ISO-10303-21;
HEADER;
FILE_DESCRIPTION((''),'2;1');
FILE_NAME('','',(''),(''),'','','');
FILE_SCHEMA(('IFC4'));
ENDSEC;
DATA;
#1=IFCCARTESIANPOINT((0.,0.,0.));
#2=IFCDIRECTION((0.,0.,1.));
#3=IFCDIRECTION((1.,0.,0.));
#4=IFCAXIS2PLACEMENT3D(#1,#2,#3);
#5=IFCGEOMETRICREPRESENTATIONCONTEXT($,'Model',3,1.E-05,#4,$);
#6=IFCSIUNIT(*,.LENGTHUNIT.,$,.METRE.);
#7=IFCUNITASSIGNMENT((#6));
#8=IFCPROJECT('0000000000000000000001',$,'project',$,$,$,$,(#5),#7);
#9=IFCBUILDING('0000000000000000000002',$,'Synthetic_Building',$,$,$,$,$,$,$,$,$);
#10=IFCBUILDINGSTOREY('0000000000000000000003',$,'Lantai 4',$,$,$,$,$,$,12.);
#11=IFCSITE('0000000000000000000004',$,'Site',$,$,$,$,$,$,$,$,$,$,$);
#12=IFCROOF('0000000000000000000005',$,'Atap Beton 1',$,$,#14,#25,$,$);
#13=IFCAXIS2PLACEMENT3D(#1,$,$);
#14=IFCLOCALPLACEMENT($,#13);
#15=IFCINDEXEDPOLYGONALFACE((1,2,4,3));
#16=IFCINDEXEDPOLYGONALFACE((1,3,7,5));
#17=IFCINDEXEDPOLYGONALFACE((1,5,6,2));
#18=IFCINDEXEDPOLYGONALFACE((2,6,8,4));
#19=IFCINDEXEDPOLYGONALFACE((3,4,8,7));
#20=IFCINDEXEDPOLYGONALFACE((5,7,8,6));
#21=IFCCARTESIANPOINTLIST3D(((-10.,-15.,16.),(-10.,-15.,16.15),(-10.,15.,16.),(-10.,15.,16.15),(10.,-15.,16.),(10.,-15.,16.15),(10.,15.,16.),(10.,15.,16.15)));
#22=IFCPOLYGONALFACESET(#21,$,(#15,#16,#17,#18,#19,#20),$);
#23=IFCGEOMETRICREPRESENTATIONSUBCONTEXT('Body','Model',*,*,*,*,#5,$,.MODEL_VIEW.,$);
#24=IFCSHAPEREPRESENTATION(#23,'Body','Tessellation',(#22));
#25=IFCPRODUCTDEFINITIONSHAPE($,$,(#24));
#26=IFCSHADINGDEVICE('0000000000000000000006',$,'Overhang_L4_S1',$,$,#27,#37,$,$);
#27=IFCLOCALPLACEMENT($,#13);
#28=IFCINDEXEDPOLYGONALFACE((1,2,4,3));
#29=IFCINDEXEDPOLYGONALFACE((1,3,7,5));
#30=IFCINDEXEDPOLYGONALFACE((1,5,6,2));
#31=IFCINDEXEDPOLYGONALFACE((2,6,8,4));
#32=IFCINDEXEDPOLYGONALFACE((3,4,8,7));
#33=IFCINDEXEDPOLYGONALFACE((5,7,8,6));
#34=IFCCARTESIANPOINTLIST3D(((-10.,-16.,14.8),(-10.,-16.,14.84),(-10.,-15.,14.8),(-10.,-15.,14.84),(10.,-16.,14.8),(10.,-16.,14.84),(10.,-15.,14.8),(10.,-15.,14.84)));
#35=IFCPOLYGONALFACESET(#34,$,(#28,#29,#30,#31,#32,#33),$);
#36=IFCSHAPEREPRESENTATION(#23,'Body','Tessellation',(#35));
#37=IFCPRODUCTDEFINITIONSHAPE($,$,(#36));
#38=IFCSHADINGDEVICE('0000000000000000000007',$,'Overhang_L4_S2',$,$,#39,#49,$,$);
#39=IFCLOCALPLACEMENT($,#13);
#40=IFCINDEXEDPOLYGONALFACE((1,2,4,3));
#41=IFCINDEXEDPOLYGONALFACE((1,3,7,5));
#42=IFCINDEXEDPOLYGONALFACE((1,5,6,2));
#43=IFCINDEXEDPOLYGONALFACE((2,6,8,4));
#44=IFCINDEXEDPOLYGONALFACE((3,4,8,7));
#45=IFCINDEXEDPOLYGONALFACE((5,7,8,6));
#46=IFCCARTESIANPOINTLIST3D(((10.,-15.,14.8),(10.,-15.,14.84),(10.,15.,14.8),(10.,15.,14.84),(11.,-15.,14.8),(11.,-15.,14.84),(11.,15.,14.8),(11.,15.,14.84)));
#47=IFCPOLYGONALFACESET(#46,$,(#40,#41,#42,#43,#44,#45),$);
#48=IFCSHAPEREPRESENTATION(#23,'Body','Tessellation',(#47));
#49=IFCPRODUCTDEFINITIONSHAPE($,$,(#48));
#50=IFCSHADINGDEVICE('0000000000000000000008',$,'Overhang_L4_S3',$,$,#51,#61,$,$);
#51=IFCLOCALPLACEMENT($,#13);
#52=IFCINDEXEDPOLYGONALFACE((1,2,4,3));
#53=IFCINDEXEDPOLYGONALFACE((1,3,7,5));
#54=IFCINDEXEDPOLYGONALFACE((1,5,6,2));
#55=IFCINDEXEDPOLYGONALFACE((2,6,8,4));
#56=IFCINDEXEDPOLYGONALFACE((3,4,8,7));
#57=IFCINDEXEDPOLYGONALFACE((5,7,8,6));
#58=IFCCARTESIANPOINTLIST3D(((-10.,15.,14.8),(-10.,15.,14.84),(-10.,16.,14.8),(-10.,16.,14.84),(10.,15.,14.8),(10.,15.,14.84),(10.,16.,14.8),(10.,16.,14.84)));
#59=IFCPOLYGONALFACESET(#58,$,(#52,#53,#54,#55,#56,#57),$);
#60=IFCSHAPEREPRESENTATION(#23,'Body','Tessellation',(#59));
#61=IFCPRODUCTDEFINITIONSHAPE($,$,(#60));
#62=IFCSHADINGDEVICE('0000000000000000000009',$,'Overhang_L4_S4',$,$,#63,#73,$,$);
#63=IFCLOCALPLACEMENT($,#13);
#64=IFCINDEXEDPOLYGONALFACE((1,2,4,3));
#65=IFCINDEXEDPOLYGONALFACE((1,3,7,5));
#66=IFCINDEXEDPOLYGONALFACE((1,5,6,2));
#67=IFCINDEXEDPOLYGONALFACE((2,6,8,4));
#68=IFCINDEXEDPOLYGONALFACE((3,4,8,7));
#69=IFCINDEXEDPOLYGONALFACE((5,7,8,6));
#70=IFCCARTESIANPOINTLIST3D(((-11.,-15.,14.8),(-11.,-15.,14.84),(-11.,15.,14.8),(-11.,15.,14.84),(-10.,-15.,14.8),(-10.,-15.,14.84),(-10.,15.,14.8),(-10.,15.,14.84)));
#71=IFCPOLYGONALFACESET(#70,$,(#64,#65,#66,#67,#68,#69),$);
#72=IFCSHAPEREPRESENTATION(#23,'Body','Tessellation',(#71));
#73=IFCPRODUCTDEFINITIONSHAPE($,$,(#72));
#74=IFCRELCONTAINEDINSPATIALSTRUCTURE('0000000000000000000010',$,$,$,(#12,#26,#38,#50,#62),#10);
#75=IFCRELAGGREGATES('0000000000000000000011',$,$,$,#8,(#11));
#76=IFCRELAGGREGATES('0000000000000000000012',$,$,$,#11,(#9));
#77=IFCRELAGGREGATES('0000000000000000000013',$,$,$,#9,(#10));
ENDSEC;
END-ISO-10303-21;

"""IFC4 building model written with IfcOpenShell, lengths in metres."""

from ifc_helpers import new_model, si_unit, frame, origin_with_axes, place, context, subcontext, project, spatial, polyline, outline, extrude, element, save


model = new_model("IFC4")

# Units and contexts
model_context = context("Model", 3, precision=1e-05, world=origin_with_axes())
body_context = subcontext(model_context, "Body", "Model", "MODEL_VIEW")
ifc_project = project(units=[si_unit("LENGTHUNIT", "METRE")], contexts=[model_context])

# Site, building, storey
site = spatial("IfcSite", under=ifc_project, Name="Site")
building = spatial("IfcBuilding", under=site, Name="Synthetic_Building")
storey = spatial("IfcBuildingStorey", under=building, Name="Lantai 4", Elevation=12.0)

# Roof
roof_placement = place(None, origin_with_axes())
element("IfcRoof", 1, at=roof_placement, inside=storey, Name="Atap Beton 1", context=body_context, shape_type="SweptSolid", body=[
    extrude(outline(polyline([(-10.0, -15.0), (10.0, -15.0), (10.0, 15.0), (-10.0, 15.0), (-10.0, -15.0)])), frame((0.0, 0.0, 16.0), z_axis=(0.0, 0.0, 1.0), x_axis=(1.0, 0.0, 0.0)), (0.0, 0.0, 1.0), 0.15),
])

# Shading devices
shading_device_1_placement = place(None, origin_with_axes())
element("IfcShadingDevice", 2, at=shading_device_1_placement, inside=storey, Name="Overhang_L4_S1", context=body_context, shape_type="SweptSolid", body=[
    extrude(outline(polyline([(-10.0, -15.0), (-10.0, -16.0), (10.0, -16.0), (10.0, -15.0), (-10.0, -15.0)])), frame((0.0, 0.0, 14.8), z_axis=(0.0, 0.0, 1.0), x_axis=(1.0, 0.0, 0.0)), (0.0, 0.0, 1.0), 0.04),
])
shading_device_2_placement = place(None, origin_with_axes())
element("IfcShadingDevice", 3, at=shading_device_2_placement, inside=storey, Name="Overhang_L4_S2", context=body_context, shape_type="SweptSolid", body=[
    extrude(outline(polyline([(10.0, -15.0), (11.0, -15.0), (11.0, 15.0), (10.0, 15.0), (10.0, -15.0)])), frame((0.0, 0.0, 14.8), z_axis=(0.0, 0.0, 1.0), x_axis=(1.0, 0.0, 0.0)), (0.0, 0.0, 1.0), 0.04),
])
shading_device_3_placement = place(None, origin_with_axes())
element("IfcShadingDevice", 4, at=shading_device_3_placement, inside=storey, Name="Overhang_L4_S3", context=body_context, shape_type="SweptSolid", body=[
    extrude(outline(polyline([(10.0, 15.0), (10.0, 16.0), (-10.0, 16.0), (-10.0, 15.0), (10.0, 15.0)])), frame((0.0, 0.0, 14.8), z_axis=(0.0, 0.0, 1.0), x_axis=(1.0, 0.0, 0.0)), (0.0, 0.0, 1.0), 0.04),
])
shading_device_4_placement = place(None, origin_with_axes())
element("IfcShadingDevice", 5, at=shading_device_4_placement, inside=storey, Name="Overhang_L4_S4", context=body_context, shape_type="SweptSolid", body=[
    extrude(outline(polyline([(-10.0, 15.0), (-11.0, 15.0), (-11.0, -15.0), (-10.0, -15.0), (-10.0, 15.0)])), frame((0.0, 0.0, 14.8), z_axis=(0.0, 0.0, 1.0), x_axis=(1.0, 0.0, 0.0)), (0.0, 0.0, 1.0), 0.04),
])

save(model, "model.ifc")
